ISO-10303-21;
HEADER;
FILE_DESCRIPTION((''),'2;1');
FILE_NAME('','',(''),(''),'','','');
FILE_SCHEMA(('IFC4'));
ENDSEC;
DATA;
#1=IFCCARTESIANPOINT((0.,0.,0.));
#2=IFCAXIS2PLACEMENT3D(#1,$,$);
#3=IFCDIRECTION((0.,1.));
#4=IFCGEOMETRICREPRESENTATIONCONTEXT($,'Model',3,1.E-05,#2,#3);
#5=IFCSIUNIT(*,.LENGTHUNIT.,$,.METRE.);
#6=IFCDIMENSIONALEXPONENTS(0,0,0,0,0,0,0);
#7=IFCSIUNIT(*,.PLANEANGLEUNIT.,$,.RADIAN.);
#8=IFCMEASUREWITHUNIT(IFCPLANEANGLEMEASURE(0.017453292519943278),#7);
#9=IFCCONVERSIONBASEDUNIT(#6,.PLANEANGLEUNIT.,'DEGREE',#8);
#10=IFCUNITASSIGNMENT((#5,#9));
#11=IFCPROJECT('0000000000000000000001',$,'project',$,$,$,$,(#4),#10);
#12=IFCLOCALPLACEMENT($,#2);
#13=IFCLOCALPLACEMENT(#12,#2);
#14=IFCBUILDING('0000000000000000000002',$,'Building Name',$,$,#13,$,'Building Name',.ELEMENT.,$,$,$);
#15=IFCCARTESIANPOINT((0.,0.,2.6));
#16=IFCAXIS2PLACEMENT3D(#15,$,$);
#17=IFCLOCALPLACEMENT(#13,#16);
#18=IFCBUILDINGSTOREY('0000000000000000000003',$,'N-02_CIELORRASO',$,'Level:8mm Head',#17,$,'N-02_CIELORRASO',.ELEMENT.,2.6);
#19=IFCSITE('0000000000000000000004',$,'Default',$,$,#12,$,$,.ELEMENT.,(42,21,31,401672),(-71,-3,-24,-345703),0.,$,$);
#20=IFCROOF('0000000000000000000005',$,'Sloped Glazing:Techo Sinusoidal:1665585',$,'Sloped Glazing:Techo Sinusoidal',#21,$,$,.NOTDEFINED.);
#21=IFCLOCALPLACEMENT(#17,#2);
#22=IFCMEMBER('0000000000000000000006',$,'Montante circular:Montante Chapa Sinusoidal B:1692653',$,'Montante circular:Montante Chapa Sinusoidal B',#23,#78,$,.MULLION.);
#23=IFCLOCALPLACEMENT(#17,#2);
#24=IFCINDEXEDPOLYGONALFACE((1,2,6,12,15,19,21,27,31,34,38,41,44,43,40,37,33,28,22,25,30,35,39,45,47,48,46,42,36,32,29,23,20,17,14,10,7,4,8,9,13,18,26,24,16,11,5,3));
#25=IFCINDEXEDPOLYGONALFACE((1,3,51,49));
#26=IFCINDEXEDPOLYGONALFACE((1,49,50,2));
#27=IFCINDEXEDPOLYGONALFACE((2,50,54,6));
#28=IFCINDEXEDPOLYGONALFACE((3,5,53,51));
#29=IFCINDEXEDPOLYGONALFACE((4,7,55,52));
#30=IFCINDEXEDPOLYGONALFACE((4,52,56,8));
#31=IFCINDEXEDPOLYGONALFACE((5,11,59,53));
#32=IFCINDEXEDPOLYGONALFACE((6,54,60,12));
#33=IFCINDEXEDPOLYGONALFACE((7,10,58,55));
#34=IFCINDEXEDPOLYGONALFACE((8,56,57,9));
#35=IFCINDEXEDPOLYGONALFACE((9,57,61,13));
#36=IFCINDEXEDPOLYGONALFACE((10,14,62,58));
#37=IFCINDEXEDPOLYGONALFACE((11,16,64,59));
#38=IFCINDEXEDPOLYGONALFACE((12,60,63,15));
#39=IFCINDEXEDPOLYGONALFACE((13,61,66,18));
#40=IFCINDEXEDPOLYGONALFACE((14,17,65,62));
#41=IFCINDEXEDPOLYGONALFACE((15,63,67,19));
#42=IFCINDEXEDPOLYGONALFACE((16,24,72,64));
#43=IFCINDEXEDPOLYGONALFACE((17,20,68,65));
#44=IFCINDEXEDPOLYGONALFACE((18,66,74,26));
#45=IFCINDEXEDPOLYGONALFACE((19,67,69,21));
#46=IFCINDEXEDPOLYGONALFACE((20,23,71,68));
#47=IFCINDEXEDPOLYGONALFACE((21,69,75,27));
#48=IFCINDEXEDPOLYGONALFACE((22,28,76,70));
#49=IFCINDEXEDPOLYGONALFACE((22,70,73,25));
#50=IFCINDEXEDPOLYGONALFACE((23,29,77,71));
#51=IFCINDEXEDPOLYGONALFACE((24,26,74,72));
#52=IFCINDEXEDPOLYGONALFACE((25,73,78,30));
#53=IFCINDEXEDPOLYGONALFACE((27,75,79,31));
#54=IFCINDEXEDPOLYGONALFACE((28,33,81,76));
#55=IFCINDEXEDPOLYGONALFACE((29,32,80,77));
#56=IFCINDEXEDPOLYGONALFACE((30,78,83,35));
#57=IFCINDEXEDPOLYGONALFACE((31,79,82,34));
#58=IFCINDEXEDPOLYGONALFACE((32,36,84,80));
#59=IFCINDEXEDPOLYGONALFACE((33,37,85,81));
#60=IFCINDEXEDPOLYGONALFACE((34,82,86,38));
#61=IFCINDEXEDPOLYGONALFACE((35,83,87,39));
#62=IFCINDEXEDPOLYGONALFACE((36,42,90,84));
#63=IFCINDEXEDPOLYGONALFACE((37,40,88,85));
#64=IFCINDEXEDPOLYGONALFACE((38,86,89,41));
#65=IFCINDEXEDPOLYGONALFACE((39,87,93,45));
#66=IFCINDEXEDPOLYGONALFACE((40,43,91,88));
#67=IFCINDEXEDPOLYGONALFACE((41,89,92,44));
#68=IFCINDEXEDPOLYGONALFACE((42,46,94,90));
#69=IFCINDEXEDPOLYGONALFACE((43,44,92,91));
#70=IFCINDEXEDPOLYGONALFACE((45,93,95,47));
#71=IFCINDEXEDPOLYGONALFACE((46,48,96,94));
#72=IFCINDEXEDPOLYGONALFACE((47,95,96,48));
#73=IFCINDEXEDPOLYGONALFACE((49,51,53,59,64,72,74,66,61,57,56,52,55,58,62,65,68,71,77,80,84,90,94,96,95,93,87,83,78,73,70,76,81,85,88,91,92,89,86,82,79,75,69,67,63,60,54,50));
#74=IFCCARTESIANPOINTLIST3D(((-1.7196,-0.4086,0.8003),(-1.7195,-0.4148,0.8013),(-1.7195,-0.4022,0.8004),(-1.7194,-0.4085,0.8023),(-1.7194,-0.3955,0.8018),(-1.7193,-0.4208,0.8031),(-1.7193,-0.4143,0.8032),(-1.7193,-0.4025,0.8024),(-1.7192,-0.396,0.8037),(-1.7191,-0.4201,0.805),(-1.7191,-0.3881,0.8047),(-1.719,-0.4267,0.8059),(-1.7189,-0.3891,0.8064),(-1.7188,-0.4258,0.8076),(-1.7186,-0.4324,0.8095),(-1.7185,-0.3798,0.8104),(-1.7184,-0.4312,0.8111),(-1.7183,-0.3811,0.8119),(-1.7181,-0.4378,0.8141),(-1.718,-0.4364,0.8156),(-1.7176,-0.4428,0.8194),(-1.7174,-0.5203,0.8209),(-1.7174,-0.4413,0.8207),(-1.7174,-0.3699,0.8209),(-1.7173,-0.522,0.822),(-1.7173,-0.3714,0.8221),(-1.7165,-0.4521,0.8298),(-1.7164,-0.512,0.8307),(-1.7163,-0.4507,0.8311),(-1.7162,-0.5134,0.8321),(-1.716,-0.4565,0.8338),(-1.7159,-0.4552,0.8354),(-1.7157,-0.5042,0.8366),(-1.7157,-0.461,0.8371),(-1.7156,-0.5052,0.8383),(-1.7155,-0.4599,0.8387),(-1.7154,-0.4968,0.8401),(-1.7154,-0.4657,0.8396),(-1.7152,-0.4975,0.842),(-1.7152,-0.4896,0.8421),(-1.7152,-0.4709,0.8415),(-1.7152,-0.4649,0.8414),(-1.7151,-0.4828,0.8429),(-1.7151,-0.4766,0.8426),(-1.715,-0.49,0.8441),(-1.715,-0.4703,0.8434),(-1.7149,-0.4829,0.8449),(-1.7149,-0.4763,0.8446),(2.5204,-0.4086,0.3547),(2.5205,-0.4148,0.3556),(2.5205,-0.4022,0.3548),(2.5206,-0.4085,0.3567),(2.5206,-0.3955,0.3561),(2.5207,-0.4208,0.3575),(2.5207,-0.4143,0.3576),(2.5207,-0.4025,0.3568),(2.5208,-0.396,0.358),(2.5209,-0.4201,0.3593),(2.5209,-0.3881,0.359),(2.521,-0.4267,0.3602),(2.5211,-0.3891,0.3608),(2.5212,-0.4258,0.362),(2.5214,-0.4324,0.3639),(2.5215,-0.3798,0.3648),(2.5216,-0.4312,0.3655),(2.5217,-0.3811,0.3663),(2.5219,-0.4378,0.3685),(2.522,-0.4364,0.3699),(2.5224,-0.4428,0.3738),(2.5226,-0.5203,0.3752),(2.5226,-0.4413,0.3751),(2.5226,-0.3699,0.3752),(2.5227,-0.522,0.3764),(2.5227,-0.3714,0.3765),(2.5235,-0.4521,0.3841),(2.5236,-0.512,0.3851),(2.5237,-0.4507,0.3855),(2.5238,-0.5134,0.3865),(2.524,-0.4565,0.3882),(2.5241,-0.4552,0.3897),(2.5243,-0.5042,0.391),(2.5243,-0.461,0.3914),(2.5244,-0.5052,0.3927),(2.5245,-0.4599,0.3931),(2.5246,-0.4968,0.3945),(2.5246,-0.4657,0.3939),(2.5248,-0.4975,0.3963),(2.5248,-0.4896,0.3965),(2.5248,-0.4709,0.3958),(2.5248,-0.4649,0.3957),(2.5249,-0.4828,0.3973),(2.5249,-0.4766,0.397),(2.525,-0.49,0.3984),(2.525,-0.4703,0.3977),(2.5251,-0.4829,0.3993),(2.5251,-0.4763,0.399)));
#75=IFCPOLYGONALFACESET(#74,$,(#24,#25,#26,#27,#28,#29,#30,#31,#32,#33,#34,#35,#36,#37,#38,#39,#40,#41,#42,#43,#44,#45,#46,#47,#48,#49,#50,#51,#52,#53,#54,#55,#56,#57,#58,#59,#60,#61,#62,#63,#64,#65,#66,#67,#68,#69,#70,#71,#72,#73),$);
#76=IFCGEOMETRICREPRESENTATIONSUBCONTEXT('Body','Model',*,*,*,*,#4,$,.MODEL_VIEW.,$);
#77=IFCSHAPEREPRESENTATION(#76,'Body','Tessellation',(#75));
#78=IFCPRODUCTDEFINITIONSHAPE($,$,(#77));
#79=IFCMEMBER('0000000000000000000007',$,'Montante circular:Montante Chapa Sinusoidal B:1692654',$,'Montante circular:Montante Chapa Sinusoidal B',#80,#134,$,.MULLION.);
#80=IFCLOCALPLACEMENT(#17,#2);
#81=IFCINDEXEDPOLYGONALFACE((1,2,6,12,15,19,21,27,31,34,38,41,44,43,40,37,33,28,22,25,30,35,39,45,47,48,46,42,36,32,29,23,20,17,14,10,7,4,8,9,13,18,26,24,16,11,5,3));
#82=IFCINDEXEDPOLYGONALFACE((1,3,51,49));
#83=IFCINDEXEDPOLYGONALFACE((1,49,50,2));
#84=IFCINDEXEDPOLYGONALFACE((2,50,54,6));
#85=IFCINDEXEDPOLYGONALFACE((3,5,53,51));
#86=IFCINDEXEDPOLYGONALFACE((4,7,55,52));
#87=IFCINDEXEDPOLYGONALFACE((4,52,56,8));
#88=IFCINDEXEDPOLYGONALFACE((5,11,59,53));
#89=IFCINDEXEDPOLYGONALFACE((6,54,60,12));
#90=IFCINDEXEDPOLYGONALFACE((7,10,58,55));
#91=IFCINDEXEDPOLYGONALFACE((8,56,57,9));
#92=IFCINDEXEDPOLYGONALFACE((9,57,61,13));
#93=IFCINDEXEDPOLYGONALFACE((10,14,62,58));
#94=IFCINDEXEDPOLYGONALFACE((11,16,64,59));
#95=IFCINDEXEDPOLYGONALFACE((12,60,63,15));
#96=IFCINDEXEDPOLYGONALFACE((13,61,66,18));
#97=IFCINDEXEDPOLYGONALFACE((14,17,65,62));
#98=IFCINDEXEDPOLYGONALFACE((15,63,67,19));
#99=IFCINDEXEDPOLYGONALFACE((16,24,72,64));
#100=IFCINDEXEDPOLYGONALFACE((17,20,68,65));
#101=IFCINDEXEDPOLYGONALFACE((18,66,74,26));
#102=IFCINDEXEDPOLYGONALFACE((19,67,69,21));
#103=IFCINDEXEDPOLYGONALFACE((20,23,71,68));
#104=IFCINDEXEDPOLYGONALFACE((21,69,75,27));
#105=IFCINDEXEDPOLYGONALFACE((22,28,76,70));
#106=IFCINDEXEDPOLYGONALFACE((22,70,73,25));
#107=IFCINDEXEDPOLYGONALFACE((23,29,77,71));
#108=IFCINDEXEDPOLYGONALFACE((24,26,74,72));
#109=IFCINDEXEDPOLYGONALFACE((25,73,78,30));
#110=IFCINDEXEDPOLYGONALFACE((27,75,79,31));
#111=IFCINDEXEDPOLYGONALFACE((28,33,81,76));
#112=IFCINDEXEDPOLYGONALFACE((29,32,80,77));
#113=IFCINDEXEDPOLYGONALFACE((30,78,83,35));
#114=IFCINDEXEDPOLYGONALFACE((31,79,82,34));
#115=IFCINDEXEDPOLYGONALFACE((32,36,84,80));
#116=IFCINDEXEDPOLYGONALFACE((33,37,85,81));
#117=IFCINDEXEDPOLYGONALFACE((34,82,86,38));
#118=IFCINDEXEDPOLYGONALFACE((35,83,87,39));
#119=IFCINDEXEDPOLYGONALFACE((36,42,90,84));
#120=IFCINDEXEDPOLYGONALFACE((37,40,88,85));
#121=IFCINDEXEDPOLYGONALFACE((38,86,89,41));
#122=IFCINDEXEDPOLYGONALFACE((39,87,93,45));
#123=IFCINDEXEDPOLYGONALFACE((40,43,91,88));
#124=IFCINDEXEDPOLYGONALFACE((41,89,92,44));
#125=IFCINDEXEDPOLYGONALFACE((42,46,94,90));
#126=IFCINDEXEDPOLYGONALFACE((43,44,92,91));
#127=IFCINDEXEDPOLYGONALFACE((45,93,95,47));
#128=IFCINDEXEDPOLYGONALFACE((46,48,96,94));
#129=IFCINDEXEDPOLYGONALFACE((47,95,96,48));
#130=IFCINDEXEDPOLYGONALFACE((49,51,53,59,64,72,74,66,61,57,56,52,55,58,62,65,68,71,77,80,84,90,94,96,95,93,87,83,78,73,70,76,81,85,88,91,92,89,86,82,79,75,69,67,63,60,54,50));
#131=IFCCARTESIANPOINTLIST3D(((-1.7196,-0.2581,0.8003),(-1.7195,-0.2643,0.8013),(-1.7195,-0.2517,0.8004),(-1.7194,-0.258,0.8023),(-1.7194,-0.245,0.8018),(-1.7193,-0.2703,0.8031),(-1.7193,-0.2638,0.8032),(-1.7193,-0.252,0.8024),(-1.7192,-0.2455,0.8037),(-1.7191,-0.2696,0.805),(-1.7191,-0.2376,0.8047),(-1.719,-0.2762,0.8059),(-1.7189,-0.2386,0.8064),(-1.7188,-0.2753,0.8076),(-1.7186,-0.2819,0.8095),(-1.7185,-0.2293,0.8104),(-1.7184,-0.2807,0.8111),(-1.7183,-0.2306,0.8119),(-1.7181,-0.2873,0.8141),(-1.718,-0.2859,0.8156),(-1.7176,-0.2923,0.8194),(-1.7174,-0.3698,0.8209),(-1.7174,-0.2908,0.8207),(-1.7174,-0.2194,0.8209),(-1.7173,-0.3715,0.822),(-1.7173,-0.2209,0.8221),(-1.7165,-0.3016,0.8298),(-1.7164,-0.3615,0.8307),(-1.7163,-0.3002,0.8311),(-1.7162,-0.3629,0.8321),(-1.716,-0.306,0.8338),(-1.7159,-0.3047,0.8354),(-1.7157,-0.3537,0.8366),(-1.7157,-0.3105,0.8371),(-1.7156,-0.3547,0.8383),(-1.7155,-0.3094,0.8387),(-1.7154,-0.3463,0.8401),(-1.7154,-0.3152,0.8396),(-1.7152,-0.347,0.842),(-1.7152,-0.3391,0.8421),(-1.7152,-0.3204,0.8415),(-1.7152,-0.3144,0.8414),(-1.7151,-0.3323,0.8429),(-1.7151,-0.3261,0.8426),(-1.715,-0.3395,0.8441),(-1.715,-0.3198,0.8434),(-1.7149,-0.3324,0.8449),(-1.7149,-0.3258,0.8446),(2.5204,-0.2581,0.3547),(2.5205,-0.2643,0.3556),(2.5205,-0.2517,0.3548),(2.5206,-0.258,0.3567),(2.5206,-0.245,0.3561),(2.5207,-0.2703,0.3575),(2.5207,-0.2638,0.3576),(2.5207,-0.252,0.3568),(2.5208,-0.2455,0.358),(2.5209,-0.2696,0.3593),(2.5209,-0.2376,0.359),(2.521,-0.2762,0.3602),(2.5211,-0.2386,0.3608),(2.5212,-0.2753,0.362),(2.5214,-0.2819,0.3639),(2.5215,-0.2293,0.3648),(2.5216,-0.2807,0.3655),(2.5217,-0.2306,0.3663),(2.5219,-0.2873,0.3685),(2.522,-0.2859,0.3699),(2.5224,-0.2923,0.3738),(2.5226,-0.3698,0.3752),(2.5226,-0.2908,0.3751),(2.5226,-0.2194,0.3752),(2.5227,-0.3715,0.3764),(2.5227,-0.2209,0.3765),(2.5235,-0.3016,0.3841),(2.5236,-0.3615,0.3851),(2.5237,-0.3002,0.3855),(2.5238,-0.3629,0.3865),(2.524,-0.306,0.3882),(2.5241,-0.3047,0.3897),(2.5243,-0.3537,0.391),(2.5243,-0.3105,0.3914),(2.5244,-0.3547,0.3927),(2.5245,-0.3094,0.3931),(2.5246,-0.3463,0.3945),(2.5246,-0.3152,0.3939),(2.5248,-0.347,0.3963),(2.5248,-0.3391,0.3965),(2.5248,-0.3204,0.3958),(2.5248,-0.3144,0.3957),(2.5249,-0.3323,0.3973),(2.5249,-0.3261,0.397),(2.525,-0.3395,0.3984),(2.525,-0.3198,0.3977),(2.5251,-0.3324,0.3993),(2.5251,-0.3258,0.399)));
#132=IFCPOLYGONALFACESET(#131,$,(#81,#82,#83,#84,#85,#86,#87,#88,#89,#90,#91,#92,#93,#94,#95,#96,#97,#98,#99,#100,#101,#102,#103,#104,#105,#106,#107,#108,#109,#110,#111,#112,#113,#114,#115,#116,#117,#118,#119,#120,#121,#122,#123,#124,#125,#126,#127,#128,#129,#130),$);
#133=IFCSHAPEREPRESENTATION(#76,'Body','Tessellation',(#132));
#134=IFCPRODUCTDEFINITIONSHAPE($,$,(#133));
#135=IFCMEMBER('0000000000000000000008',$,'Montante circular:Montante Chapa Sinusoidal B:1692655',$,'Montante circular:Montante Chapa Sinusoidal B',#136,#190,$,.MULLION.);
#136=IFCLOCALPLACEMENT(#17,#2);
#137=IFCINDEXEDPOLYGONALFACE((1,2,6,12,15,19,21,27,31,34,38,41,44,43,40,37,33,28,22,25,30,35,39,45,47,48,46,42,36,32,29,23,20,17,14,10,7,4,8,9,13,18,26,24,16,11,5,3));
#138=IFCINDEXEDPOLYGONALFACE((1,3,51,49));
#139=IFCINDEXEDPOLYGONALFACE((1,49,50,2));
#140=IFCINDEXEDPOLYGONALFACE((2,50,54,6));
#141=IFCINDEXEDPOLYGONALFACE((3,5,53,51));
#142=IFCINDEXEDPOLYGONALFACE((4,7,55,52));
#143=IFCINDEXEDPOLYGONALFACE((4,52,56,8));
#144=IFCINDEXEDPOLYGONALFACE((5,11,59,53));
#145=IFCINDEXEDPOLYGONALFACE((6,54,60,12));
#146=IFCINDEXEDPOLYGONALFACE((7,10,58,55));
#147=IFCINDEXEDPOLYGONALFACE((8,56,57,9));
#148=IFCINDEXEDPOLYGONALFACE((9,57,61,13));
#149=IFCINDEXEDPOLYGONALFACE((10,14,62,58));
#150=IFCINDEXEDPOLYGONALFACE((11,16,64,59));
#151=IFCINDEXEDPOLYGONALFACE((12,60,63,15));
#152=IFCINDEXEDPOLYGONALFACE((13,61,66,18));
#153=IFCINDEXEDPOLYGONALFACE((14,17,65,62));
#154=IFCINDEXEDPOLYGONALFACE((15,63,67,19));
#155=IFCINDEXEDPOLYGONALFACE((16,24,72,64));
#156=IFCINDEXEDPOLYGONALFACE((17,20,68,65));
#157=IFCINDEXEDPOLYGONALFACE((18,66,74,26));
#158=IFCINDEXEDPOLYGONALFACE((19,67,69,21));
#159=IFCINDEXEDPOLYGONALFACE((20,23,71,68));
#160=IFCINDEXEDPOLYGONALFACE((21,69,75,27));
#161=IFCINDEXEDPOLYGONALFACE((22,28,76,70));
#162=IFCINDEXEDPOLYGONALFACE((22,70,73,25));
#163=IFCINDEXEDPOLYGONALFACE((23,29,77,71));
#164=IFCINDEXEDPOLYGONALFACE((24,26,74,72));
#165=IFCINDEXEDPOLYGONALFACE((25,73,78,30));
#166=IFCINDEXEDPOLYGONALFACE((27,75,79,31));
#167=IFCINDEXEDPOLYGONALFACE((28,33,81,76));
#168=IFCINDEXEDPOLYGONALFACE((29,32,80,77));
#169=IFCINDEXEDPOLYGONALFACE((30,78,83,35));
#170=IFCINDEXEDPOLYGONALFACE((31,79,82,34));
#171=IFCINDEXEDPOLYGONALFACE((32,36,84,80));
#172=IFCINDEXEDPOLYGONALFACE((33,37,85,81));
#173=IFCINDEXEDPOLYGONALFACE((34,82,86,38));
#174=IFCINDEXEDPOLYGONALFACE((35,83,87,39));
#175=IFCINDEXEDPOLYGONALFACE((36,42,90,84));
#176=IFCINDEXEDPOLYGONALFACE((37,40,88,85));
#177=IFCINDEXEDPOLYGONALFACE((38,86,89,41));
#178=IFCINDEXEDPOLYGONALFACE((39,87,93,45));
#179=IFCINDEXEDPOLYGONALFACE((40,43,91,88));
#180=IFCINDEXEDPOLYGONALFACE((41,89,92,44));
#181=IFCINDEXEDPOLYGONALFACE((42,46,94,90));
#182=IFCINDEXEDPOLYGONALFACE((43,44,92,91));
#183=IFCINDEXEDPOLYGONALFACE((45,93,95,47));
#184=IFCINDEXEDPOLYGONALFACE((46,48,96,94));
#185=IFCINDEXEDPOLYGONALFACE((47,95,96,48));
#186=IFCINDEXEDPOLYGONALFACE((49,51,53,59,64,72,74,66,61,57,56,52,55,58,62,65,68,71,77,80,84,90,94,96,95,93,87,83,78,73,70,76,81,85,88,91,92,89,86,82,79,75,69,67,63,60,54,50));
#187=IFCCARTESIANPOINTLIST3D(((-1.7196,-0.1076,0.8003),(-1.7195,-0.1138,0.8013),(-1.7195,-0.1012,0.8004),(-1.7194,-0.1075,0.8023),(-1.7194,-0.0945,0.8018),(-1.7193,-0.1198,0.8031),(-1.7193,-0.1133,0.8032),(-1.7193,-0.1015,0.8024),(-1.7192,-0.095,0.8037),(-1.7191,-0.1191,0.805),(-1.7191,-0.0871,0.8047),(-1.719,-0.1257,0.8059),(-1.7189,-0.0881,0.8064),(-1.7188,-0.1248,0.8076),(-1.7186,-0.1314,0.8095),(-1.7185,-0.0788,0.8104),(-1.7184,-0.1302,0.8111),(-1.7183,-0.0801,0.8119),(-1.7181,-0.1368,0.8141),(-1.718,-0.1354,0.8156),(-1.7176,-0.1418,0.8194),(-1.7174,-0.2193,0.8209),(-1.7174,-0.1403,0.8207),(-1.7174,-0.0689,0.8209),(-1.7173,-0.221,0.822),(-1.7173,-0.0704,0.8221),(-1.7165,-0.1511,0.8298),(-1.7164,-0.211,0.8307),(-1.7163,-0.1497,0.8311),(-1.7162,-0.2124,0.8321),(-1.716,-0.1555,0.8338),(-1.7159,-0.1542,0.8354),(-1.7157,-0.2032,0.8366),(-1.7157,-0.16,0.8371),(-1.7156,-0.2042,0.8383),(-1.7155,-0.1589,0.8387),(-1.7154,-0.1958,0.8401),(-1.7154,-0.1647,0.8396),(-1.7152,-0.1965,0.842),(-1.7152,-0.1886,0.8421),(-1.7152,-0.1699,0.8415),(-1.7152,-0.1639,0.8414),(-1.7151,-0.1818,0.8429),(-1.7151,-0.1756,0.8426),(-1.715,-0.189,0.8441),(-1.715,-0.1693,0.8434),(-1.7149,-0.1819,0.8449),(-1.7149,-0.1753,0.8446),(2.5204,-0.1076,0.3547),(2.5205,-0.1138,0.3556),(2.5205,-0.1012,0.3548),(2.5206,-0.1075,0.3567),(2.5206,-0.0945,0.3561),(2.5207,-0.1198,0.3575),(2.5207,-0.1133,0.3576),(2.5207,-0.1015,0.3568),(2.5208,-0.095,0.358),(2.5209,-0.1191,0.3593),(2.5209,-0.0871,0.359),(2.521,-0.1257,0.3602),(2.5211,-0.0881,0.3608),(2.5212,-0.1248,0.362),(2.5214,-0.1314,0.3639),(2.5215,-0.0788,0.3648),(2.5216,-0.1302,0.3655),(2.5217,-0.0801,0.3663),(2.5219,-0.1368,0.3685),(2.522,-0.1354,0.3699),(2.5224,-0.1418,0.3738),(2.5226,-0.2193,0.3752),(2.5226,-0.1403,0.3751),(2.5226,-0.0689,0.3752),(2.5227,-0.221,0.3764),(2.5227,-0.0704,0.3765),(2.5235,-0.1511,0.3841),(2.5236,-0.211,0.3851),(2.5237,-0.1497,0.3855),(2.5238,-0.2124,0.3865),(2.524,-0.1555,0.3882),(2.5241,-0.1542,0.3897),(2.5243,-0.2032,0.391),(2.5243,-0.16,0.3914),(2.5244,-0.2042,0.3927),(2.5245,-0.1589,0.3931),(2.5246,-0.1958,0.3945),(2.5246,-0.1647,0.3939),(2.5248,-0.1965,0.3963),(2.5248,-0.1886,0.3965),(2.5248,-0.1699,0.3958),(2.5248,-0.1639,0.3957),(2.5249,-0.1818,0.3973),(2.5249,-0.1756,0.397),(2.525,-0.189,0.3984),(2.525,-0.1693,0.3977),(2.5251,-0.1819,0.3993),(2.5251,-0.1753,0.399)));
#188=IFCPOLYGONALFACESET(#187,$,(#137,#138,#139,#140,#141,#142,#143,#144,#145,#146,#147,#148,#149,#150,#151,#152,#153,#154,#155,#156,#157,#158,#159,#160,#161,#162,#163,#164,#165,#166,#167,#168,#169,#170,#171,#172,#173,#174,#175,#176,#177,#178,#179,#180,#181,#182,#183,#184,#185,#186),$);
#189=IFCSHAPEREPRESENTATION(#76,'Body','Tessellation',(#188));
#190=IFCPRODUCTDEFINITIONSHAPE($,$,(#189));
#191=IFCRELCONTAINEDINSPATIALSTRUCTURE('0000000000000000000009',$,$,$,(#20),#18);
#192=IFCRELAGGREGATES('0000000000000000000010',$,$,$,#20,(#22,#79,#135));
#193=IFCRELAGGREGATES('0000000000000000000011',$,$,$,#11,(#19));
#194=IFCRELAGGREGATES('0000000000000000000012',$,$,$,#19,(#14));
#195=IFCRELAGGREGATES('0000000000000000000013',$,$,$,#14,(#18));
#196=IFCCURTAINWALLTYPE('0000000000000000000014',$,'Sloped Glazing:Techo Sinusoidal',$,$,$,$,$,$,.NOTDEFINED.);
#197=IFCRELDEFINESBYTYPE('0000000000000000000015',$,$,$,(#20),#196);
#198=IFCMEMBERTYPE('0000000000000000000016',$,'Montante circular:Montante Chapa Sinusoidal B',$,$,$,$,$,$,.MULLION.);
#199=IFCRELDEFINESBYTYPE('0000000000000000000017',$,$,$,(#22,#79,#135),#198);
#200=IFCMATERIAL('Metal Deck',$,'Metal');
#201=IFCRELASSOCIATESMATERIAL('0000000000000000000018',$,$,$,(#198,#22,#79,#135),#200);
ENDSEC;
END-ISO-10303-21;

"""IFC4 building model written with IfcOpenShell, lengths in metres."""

from ifc_helpers import new_model, entity, si_unit, converted_unit, direction, frame, origin, place, context, subcontext, project, spatial, indexed_curve, outline, extrude, source, transform, mapped, material, type_object, type_shapes, element, aggregate, save


model = new_model("IFC4")

# Units and contexts
model_context = context("Model", 3, precision=1e-05, world=origin(), true_north=direction((0.0, 1.0)))
body_context = subcontext(model_context, "Body", "Model", "MODEL_VIEW")
ifc_project = project(units=[si_unit("LENGTHUNIT", "METRE"), converted_unit("PLANEANGLEUNIT", "DEGREE", entity("IfcPlaneAngleMeasure", 0.017453292519943278), si_unit("PLANEANGLEUNIT", "RADIAN"), dimensions=[0, 0, 0, 0, 0, 0, 0])], contexts=[model_context])

# Site, building, storey
site_placement = place(None, origin())
site = spatial("IfcSite", under=ifc_project, at=site_placement, Name="Default", CompositionType="ELEMENT", RefLatitude=(42, 21, 31, 401672), RefLongitude=(-71, -3, -24, -345703), RefElevation=0.0)
building_placement = place(site_placement, origin())
building = spatial("IfcBuilding", under=site, at=building_placement, Name="Building Name", LongName="Building Name", CompositionType="ELEMENT")
storey_placement = place(building_placement, frame((0.0, 0.0, 2.6)))
storey = spatial("IfcBuildingStorey", under=building, at=storey_placement, Name="N-02_CIELORRASO", ObjectType="Level:8mm Head", LongName="N-02_CIELORRASO", CompositionType="ELEMENT", Elevation=2.6)

# Roof, members
curtain_wall_type = type_object("IfcCurtainWallType", Name="Sloped Glazing:Techo Sinusoidal", PredefinedType="NOTDEFINED")
roof_placement = place(storey_placement, frame((0.0, 0.0, -2.6)))
roof = element("IfcRoof", 1, at=roof_placement, inside=storey, type_object=curtain_wall_type, Name="Sloped Glazing:Techo Sinusoidal:1665585", ObjectType="Sloped Glazing:Techo Sinusoidal", PredefinedType="NOTDEFINED")
ifc_material = material(Name="Metal Deck", Category="Metal")
member_type = type_object("IfcMemberType", Name="Montante circular:Montante Chapa Sinusoidal B", PredefinedType="MULLION", material=ifc_material)
shared_shape = source(origin(), body_context, "Body", "SweptSolid", [
    extrude(outline(indexed_curve([(0.0595, -0.0443), (0.0615, -0.0443), (0.0603, -0.031), (0.0572, -0.0213), (0.053, -0.0138), (0.0481, -0.0078), (0.0427, -0.003), (0.0372, 0.0005), (0.0315, 0.0029), (0.0259, 0.0044), (0.0203, 0.0051), (0.0146, 0.005), (0.0084, 0.0041), (-0.0053, 0.0009), (-0.0123, -0.0005), (-0.0191, -0.0012), (-0.0256, -0.001), (-0.0317, 0.0001), (-0.0375, 0.0019), (-0.0428, 0.0046), (-0.0477, 0.0081), (-0.0522, 0.0128), (-0.0563, 0.0191), (-0.0597, 0.0282), (-0.0617, 0.0421), (-0.0637, 0.042), (-0.0616, 0.0277), (-0.0581, 0.0182), (-0.0537, 0.0116), (-0.049, 0.0066), (-0.0438, 0.0028), (-0.0382, 0.0001), (-0.0322, -0.0019), (-0.0258, -0.003), (-0.019, -0.0032), (-0.012, -0.0025), (-0.0048, -0.0011), (0.0088, 0.0021), (0.0147, 0.003), (0.0202, 0.0031), (0.0255, 0.0024), (0.0309, 0.001), (0.0362, -0.0013), (0.0415, -0.0046), (0.0466, -0.0092), (0.0513, -0.0149), (0.0554, -0.0221), (0.0584, -0.0314), (0.0595, -0.0443)], self_intersect=False)), frame((-0.007, 0.0228, -4.2634), z_axis=(0.0, 0.0, 1.0), x_axis=(-0.819152, -0.573576, 0.0)), (0.0, 0.0, 1.0), 4.2634),
])
type_shapes(member_type, [shared_shape])
member_1_placement = place(roof_placement, frame((-1.7148, -0.4391, 3.4456), z_axis=(-0.994522, 0.0, 0.104528), x_axis=(0.0, 1.0, 0.0)))
member_1 = element("IfcMember", 2, at=member_1_placement, type_object=member_type, material=ifc_material, Name="Montante circular:Montante Chapa Sinusoidal B:1692653", ObjectType="Montante circular:Montante Chapa Sinusoidal B", PredefinedType="MULLION", context=body_context, shape_type="MappedRepresentation", body=[
    mapped(shared_shape, transform((0.0, 0.0, 0.0), scale=1.0)),
])
member_2_placement = place(roof_placement, frame((-1.7148, -0.2886, 3.4456), z_axis=(-0.994522, 0.0, 0.104528), x_axis=(0.0, 1.0, 0.0)))
member_2 = element("IfcMember", 3, at=member_2_placement, type_object=member_type, material=ifc_material, Name="Montante circular:Montante Chapa Sinusoidal B:1692654", ObjectType="Montante circular:Montante Chapa Sinusoidal B", PredefinedType="MULLION", context=body_context, shape_type="MappedRepresentation", body=[
    mapped(shared_shape, transform((0.0, 0.0, 0.0), scale=1.0)),
])
member_3_placement = place(roof_placement, frame((-1.7148, -0.1381, 3.4456), z_axis=(-0.994522, 0.0, 0.104528), x_axis=(0.0, 1.0, 0.0)))
member_3 = element("IfcMember", 4, at=member_3_placement, type_object=member_type, material=ifc_material, Name="Montante circular:Montante Chapa Sinusoidal B:1692655", ObjectType="Montante circular:Montante Chapa Sinusoidal B", PredefinedType="MULLION", context=body_context, shape_type="MappedRepresentation", body=[
    mapped(shared_shape, transform((0.0, 0.0, 0.0), scale=1.0)),
])
aggregate(roof, [member_1, member_2, member_3])

save(model, "model.ifc")
